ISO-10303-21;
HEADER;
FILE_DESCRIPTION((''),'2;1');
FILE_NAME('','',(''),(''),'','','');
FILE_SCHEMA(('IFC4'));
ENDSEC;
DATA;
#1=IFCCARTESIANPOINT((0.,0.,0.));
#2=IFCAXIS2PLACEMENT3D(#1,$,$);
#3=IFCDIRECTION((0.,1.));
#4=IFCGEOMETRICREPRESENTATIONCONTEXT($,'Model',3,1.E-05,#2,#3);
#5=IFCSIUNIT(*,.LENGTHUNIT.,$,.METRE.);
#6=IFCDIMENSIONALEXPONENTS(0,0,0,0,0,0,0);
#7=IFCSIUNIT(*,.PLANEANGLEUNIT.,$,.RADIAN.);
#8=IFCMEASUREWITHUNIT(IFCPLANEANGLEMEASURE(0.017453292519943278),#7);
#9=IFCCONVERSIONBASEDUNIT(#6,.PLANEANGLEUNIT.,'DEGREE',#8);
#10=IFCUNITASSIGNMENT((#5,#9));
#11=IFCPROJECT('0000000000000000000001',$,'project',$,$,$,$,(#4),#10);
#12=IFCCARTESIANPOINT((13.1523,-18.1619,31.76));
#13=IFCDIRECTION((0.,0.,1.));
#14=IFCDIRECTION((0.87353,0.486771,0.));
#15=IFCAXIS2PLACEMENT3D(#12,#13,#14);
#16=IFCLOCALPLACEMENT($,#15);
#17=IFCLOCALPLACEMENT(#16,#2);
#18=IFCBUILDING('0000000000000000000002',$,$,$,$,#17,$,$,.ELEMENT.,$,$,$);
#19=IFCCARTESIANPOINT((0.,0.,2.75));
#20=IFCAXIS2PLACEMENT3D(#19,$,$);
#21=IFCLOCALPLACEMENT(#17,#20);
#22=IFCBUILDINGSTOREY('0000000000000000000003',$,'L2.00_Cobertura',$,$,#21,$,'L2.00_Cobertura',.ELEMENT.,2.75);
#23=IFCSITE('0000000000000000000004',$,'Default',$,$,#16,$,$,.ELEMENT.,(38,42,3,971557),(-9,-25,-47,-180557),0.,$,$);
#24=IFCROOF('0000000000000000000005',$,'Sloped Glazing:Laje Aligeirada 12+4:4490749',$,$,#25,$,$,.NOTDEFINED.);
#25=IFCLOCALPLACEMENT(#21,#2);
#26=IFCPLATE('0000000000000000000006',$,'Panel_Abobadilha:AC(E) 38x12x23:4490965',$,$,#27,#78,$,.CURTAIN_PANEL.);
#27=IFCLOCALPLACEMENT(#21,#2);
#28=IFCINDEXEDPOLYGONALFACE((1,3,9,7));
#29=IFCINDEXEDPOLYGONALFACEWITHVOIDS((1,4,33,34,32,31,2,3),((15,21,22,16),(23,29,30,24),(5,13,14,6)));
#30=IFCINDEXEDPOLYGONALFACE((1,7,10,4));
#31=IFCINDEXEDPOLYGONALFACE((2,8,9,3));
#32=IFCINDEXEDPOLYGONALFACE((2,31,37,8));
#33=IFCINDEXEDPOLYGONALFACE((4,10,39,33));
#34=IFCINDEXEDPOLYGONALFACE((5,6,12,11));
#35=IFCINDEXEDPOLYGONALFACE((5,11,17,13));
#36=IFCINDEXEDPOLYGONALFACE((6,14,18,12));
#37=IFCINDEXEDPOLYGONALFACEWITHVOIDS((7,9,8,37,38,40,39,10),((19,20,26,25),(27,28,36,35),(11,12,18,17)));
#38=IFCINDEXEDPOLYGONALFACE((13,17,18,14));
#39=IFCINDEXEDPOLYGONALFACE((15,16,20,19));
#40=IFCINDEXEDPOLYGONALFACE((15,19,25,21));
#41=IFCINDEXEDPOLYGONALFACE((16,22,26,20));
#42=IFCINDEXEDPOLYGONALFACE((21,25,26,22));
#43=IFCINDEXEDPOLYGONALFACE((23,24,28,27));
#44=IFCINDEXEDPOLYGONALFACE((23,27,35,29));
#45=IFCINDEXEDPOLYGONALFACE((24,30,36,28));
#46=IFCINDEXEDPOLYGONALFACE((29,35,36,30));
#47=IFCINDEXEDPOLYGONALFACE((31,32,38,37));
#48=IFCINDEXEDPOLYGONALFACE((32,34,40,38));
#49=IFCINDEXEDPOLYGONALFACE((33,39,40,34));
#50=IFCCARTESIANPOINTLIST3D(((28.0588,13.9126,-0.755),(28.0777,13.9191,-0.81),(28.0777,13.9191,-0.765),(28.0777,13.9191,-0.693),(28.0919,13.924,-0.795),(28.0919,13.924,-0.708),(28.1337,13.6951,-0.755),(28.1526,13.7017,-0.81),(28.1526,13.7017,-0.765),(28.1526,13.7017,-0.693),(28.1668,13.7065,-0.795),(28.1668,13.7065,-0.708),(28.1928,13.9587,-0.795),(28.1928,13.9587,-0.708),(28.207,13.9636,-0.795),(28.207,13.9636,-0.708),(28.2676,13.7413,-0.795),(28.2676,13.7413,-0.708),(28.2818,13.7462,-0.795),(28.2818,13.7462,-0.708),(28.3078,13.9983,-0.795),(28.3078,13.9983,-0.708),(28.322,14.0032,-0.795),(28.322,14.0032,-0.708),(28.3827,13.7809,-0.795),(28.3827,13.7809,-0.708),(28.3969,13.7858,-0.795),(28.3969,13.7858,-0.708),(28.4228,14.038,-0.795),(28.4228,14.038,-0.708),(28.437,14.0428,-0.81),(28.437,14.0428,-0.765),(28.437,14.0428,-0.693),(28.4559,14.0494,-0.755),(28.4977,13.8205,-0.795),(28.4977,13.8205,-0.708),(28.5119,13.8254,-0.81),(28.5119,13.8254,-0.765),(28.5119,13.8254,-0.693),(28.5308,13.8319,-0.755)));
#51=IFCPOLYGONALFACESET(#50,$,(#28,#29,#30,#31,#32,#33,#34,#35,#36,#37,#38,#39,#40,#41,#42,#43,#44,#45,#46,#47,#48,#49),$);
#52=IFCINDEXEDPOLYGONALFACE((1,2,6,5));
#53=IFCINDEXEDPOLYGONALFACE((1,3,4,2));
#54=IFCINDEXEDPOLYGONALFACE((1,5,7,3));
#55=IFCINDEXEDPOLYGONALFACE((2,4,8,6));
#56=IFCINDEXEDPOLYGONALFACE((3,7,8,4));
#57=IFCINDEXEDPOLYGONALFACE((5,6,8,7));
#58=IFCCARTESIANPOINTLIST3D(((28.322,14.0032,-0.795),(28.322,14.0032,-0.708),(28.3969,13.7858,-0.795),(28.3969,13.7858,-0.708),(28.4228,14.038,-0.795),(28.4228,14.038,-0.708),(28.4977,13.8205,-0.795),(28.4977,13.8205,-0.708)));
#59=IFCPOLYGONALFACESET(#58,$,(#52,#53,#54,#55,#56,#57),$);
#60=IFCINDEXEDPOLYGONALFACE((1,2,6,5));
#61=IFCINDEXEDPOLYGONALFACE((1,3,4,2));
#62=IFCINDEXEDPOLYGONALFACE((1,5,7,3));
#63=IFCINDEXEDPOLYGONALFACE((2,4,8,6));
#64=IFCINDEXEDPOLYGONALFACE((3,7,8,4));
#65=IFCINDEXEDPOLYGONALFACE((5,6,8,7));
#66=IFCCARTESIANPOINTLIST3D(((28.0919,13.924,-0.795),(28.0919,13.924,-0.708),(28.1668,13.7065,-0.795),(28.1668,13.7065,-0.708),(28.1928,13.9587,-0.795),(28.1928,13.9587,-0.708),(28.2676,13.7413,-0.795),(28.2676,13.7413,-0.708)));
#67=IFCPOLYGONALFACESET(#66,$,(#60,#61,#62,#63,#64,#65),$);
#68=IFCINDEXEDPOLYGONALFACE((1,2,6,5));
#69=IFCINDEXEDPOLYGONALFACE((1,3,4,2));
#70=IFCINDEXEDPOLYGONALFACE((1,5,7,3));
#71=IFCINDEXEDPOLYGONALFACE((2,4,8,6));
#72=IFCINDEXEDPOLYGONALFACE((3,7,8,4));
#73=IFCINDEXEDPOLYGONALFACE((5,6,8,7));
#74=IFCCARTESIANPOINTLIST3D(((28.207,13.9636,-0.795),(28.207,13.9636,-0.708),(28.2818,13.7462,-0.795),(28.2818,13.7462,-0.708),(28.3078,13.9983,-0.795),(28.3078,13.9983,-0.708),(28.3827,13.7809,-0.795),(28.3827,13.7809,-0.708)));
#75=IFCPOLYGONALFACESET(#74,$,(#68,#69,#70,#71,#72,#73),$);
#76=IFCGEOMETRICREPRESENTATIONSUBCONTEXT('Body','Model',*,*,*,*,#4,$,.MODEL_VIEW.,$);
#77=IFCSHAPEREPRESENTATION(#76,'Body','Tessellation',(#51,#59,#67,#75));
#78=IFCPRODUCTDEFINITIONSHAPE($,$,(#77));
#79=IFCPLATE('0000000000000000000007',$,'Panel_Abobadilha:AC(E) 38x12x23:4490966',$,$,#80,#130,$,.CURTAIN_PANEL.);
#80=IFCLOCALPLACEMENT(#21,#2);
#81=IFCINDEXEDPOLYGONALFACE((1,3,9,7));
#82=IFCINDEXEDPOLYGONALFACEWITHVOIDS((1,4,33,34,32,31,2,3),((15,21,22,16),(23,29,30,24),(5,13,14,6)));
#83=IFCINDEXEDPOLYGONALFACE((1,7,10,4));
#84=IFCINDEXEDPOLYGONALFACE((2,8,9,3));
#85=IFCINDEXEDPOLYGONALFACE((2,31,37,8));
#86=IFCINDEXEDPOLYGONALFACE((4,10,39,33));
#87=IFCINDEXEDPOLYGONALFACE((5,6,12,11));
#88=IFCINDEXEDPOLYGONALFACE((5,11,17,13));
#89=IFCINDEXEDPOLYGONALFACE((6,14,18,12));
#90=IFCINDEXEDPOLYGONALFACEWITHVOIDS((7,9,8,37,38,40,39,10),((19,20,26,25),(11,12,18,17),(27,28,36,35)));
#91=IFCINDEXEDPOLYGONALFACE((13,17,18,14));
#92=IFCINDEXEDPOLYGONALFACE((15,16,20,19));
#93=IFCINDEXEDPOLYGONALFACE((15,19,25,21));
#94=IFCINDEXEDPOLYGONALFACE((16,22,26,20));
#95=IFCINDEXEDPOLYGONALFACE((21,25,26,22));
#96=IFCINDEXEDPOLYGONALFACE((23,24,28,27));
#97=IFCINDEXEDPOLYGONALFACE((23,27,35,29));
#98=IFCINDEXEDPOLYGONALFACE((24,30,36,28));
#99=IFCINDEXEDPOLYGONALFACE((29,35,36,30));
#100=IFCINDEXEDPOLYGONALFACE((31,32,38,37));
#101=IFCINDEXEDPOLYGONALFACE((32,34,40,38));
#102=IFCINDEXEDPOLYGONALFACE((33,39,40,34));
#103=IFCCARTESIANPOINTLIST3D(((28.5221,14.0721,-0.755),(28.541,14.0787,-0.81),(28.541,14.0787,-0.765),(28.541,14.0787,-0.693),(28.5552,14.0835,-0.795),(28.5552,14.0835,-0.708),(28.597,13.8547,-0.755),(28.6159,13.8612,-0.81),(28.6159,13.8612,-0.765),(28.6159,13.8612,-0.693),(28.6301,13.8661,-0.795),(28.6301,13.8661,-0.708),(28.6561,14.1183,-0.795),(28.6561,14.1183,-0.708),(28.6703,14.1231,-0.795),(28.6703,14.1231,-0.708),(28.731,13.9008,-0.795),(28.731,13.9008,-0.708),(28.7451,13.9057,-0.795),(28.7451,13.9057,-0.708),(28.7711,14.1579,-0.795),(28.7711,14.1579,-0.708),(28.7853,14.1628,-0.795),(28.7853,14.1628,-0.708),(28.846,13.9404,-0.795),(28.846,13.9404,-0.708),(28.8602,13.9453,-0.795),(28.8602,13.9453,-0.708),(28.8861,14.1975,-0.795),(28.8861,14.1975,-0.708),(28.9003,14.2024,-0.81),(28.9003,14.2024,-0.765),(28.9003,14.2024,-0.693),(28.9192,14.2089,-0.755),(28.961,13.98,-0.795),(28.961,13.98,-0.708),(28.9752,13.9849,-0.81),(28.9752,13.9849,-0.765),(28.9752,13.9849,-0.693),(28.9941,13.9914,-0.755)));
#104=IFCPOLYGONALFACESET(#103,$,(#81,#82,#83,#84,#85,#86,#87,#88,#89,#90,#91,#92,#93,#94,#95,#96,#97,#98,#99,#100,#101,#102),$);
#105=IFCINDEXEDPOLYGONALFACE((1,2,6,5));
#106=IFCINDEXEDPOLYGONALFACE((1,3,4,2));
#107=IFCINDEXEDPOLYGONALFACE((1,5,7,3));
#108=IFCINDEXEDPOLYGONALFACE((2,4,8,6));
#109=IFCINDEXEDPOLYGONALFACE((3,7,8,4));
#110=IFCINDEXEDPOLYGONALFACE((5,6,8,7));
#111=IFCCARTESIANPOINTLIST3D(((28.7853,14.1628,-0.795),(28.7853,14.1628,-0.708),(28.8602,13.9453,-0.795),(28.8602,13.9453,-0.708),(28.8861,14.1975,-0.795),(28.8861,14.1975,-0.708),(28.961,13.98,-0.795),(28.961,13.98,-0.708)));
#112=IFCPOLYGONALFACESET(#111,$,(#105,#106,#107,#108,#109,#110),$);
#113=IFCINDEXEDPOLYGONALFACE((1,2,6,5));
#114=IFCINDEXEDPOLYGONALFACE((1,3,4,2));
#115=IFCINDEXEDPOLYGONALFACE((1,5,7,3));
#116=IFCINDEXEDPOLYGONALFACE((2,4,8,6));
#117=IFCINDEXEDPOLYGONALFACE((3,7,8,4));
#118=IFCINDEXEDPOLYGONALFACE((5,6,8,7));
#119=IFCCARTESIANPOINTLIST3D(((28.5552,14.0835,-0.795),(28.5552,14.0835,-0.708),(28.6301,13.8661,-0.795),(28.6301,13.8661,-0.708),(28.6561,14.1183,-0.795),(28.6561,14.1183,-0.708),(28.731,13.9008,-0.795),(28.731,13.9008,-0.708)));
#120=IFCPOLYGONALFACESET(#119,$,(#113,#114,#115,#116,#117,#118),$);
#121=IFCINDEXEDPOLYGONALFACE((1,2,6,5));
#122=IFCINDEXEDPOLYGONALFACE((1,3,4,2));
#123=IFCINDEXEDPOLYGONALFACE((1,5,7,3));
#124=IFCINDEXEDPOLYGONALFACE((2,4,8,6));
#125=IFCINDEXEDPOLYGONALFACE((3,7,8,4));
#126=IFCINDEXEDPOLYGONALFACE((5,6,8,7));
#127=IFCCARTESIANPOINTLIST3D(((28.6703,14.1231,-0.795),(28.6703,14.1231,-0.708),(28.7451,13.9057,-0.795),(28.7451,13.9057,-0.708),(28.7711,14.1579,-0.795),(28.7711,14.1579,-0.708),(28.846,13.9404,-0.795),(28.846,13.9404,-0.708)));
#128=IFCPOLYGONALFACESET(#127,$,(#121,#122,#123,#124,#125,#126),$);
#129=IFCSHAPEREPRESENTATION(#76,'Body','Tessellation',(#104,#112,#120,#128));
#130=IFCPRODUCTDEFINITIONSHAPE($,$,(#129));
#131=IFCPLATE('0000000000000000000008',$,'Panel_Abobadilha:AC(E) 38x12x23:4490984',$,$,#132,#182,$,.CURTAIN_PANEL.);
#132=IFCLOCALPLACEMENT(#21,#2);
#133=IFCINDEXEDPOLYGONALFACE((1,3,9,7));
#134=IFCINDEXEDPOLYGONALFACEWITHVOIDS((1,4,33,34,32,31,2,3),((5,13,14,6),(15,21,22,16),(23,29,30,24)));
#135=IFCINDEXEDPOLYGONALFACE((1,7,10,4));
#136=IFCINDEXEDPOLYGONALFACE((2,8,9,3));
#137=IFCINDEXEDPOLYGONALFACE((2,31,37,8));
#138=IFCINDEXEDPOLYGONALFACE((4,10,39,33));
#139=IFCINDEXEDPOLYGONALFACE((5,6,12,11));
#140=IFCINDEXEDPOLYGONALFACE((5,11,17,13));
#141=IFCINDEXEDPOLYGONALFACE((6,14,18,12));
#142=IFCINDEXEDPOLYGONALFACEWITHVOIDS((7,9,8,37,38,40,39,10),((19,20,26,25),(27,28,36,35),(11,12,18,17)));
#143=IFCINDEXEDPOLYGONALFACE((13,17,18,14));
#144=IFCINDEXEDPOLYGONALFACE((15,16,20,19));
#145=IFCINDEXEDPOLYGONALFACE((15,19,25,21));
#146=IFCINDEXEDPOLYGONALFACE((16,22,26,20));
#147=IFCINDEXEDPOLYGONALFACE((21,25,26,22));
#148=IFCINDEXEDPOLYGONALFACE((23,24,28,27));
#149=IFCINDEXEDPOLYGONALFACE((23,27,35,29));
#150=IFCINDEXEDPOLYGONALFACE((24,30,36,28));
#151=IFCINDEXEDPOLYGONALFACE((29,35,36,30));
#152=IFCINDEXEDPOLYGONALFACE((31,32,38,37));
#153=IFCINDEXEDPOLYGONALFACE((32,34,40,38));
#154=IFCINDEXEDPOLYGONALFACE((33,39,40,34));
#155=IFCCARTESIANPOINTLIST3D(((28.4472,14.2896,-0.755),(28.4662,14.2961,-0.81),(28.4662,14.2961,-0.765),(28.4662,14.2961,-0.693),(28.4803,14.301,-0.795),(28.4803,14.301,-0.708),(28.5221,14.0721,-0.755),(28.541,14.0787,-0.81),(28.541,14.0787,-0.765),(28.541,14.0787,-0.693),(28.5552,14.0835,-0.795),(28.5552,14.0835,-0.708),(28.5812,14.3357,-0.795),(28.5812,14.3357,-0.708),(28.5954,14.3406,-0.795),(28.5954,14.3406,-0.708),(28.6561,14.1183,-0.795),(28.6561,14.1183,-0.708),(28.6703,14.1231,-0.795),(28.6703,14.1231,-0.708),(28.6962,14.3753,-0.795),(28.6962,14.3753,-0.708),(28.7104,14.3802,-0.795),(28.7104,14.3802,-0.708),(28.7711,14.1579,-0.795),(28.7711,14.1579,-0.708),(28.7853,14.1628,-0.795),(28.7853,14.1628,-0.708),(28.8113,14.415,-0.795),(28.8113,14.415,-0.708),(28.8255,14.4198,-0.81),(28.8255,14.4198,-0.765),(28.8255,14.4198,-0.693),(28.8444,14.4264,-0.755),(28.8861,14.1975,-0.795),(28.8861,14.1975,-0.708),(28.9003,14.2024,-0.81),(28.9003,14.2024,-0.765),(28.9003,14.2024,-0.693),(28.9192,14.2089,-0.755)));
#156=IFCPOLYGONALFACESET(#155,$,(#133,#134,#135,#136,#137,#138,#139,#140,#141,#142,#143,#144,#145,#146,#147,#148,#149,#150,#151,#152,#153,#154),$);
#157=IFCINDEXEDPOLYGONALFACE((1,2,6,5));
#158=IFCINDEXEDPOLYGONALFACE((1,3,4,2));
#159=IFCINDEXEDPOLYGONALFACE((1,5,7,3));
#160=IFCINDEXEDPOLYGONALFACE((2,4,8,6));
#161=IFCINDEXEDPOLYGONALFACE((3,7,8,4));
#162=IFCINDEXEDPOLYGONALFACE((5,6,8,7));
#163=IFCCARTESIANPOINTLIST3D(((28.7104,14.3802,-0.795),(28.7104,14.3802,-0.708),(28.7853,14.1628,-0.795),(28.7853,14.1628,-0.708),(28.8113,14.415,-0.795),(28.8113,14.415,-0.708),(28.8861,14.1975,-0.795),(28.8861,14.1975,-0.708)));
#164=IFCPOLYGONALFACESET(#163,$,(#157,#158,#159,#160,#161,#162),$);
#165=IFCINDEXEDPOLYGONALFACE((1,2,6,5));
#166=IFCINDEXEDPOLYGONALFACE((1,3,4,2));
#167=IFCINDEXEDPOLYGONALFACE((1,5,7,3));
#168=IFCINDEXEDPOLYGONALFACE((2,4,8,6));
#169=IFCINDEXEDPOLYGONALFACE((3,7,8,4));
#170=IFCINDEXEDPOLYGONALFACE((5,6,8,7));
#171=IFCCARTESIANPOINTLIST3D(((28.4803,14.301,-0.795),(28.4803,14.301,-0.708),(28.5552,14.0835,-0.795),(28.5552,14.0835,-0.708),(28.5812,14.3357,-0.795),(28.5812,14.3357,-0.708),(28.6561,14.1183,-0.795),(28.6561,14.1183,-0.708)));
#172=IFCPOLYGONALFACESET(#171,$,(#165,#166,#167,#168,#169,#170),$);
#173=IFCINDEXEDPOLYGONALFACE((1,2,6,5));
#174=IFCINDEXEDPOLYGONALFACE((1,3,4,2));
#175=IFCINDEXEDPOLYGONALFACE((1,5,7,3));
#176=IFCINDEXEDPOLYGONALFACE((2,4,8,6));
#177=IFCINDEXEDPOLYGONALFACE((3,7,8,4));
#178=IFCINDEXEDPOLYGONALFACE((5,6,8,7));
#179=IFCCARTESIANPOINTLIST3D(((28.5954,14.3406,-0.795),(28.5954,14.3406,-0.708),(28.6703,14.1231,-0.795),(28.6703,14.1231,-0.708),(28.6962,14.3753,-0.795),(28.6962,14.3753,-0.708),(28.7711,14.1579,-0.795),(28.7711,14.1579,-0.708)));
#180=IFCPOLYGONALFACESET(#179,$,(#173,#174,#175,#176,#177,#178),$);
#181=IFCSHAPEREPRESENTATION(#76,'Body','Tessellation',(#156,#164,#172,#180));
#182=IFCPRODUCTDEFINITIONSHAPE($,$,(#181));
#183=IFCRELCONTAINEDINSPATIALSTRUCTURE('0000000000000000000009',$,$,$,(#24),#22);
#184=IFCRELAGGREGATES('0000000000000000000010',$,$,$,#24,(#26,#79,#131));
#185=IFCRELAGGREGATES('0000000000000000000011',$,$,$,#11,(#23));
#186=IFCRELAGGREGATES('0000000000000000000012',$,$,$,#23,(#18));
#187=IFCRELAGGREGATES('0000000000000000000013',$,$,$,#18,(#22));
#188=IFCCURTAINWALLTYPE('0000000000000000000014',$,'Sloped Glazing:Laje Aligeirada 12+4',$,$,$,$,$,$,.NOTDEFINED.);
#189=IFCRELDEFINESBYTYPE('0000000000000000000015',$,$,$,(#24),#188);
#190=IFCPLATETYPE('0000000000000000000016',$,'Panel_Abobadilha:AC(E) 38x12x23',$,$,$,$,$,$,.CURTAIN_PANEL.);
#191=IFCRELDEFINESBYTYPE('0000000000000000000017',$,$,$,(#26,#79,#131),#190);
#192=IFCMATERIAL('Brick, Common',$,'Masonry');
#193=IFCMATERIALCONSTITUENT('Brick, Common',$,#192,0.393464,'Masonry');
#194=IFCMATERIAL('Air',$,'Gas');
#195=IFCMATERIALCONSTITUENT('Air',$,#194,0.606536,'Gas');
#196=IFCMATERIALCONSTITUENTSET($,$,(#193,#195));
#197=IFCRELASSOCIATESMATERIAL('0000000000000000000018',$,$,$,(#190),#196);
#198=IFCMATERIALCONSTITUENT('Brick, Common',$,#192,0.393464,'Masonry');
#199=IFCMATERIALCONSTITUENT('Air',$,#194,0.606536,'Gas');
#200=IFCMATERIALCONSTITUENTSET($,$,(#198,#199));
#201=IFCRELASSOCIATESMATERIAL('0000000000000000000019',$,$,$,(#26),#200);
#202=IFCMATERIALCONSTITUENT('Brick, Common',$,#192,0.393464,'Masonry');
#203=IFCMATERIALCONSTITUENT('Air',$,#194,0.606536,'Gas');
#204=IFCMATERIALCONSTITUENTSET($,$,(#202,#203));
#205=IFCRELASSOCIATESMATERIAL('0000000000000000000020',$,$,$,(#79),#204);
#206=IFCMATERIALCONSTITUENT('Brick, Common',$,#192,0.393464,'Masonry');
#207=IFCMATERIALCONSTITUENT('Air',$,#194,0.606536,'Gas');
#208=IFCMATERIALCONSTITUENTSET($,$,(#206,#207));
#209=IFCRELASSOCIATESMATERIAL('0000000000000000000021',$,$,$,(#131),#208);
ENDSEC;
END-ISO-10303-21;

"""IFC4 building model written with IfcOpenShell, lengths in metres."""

from ifc_helpers import new_model, entity, si_unit, converted_unit, direction, frame, origin, place, context, subcontext, project, spatial, indexed_curve, outline, extrude, source, transform, mapped, material, constituent, constituent_set, type_object, type_shapes, element, aggregate, save


model = new_model("IFC4")

# Units and contexts
model_context = context("Model", 3, precision=1e-05, world=origin(), true_north=direction((0.0, 1.0)))
body_context = subcontext(model_context, "Body", "Model", "MODEL_VIEW")
ifc_project = project(units=[si_unit("LENGTHUNIT", "METRE"), converted_unit("PLANEANGLEUNIT", "DEGREE", entity("IfcPlaneAngleMeasure", 0.017453292519943278), si_unit("PLANEANGLEUNIT", "RADIAN"), dimensions=[0, 0, 0, 0, 0, 0, 0])], contexts=[model_context])

# Site, building, storey
site_placement = place(None, frame((13.1523, -18.1619, 31.76), z_axis=(0.0, 0.0, 1.0), x_axis=(0.87353, 0.486771, 0.0)))
site = spatial("IfcSite", under=ifc_project, at=site_placement, Name="Default", CompositionType="ELEMENT", RefLatitude=(38, 42, 3, 971557), RefLongitude=(-9, -25, -47, -180557), RefElevation=0.0)
building_placement = place(site_placement, origin())
building = spatial("IfcBuilding", under=site, at=building_placement, CompositionType="ELEMENT")
storey_placement = place(building_placement, frame((0.0, 0.0, 2.75)))
storey = spatial("IfcBuildingStorey", under=building, at=storey_placement, Name="L2.00_Cobertura", LongName="L2.00_Cobertura", CompositionType="ELEMENT", Elevation=2.75)

# Roof, plates
curtain_wall_type = type_object("IfcCurtainWallType", Name="Sloped Glazing:Laje Aligeirada 12+4", PredefinedType="NOTDEFINED")
roof_placement = place(storey_placement, frame((0.0, 0.0, -2.75)))
roof = element("IfcRoof", 1, at=roof_placement, inside=storey, type_object=curtain_wall_type, Name="Sloped Glazing:Laje Aligeirada 12+4:4490749", PredefinedType="NOTDEFINED")
ifc_material_1 = material(Name="Brick, Common", Category="Masonry")
ifc_material_2 = material(Name="Air", Category="Gas")
ifc_constituent_1 = constituent(ifc_material_1, Name="Brick, Common", Category="Masonry", fraction=0.393464)
ifc_constituent_2 = constituent(ifc_material_2, Name="Air", Category="Gas", fraction=0.606536)
ifc_constituent_set_1 = constituent_set(constituents=[ifc_constituent_1, ifc_constituent_2])
plate_type_1 = type_object("IfcPlateType", Name="Panel_Abobadilha:AC(E) 38x12x23", PredefinedType="CURTAIN_PANEL", material=ifc_constituent_set_1)
shared_shape_1 = source(origin(), body_context, "Body", "SweptSolid", [
    extrude(outline(indexed_curve([(-0.19, -0.0543), (0.19, -0.0543), (0.19, -0.0093), (0.21, 0.0007), (0.19, 0.0628), (-0.19, 0.0628), (-0.21, 0.0007), (-0.19, -0.0093), (-0.19, -0.0543)], self_intersect=False), holes=[indexed_curve([(-0.0683, 0.0477), (-0.0683, -0.0393), (-0.175, -0.0393), (-0.175, 0.0477), (-0.0683, 0.0477)], self_intersect=False), indexed_curve([(0.0533, 0.0477), (0.0533, -0.0393), (-0.0533, -0.0393), (-0.0533, 0.0477), (0.0533, 0.0477)], self_intersect=False), indexed_curve([(0.175, 0.0477), (0.175, -0.0393), (0.0683, -0.0393), (0.0683, 0.0477), (0.175, 0.0477)], self_intersect=False)]), frame((0.0, 0.0543, 0.0)), (0.0, 0.0, 1.0), 0.23),
    extrude(outline(indexed_curve([(-0.0533, -0.0435), (0.0533, -0.0435), (0.0533, 0.0435), (-0.0533, 0.0435), (-0.0533, -0.0435)], self_intersect=False)), frame((0.1217, 0.0585, 0.0), z_axis=(0.0, 0.0, 1.0), x_axis=(-1.0, 0.0, 0.0)), (0.0, 0.0, 1.0), 0.23),
    extrude(outline(indexed_curve([(-0.0533, -0.0435), (0.0533, -0.0435), (0.0533, 0.0435), (-0.0533, 0.0435), (-0.0533, -0.0435)], self_intersect=False)), frame((-0.1217, 0.0585, 0.0), z_axis=(0.0, 0.0, 1.0), x_axis=(-1.0, 0.0, 0.0)), (0.0, 0.0, 1.0), 0.23),
    extrude(outline(indexed_curve([(-0.0533, -0.0435), (0.0533, -0.0435), (0.0533, 0.0435), (-0.0533, 0.0435), (-0.0533, -0.0435)], self_intersect=False)), frame((0.0, 0.0585, 0.0), z_axis=(0.0, 0.0, 1.0), x_axis=(-1.0, 0.0, 0.0)), (0.0, 0.0, 1.0), 0.23),
])
type_shapes(plate_type_1, [shared_shape_1])
ifc_constituent_3 = constituent(ifc_material_1, Name="Brick, Common", Category="Masonry", fraction=0.393464)
ifc_constituent_4 = constituent(ifc_material_2, Name="Air", Category="Gas", fraction=0.606536)
ifc_constituent_set_2 = constituent_set(constituents=[ifc_constituent_3, ifc_constituent_4])
plate_1_placement = place(roof_placement, frame((28.2574, 13.981, 1.94), z_axis=(0.325568, -0.945519, 0.0), x_axis=(0.945519, 0.325568, 0.0)))
plate_1 = element("IfcPlate", 2, at=plate_1_placement, type_object=plate_type_1, material=ifc_constituent_set_2, Name="Panel_Abobadilha:AC(E) 38x12x23:4490965", PredefinedType="CURTAIN_PANEL", context=body_context, shape_type="MappedRepresentation", body=[
    mapped(shared_shape_1, transform((0.0, 0.0, 0.0), scale=1.0)),
])
ifc_constituent_5 = constituent(ifc_material_1, Name="Brick, Common", Category="Masonry", fraction=0.393464)
ifc_constituent_6 = constituent(ifc_material_2, Name="Air", Category="Gas", fraction=0.606536)
ifc_constituent_set_3 = constituent_set(constituents=[ifc_constituent_5, ifc_constituent_6])
plate_2_placement = place(roof_placement, frame((28.7207, 14.1405, 1.94), z_axis=(0.325568, -0.945519, 0.0), x_axis=(0.945519, 0.325568, 0.0)))
plate_2 = element("IfcPlate", 3, at=plate_2_placement, type_object=plate_type_1, material=ifc_constituent_set_3, Name="Panel_Abobadilha:AC(E) 38x12x23:4490966", PredefinedType="CURTAIN_PANEL", context=body_context, shape_type="MappedRepresentation", body=[
    mapped(shared_shape_1, transform((0.0, 0.0, 0.0), scale=1.0)),
])
ifc_constituent_7 = constituent(ifc_material_1, Name="Brick, Common", Category="Masonry", fraction=0.393464)
ifc_constituent_8 = constituent(ifc_material_2, Name="Air", Category="Gas", fraction=0.606536)
ifc_constituent_set_4 = constituent_set(constituents=[ifc_constituent_7, ifc_constituent_8])
plate_3_placement = place(roof_placement, frame((28.6458, 14.358, 1.94), z_axis=(0.325568, -0.945519, 0.0), x_axis=(0.945519, 0.325568, 0.0)))
plate_3 = element("IfcPlate", 4, at=plate_3_placement, type_object=plate_type_1, material=ifc_constituent_set_4, Name="Panel_Abobadilha:AC(E) 38x12x23:4490984", PredefinedType="CURTAIN_PANEL", context=body_context, shape_type="MappedRepresentation", body=[
    mapped(shared_shape_1, transform((0.0, 0.0, 0.0), scale=1.0)),
])
aggregate(roof, [plate_1, plate_2, plate_3])

save(model, "model.ifc")
